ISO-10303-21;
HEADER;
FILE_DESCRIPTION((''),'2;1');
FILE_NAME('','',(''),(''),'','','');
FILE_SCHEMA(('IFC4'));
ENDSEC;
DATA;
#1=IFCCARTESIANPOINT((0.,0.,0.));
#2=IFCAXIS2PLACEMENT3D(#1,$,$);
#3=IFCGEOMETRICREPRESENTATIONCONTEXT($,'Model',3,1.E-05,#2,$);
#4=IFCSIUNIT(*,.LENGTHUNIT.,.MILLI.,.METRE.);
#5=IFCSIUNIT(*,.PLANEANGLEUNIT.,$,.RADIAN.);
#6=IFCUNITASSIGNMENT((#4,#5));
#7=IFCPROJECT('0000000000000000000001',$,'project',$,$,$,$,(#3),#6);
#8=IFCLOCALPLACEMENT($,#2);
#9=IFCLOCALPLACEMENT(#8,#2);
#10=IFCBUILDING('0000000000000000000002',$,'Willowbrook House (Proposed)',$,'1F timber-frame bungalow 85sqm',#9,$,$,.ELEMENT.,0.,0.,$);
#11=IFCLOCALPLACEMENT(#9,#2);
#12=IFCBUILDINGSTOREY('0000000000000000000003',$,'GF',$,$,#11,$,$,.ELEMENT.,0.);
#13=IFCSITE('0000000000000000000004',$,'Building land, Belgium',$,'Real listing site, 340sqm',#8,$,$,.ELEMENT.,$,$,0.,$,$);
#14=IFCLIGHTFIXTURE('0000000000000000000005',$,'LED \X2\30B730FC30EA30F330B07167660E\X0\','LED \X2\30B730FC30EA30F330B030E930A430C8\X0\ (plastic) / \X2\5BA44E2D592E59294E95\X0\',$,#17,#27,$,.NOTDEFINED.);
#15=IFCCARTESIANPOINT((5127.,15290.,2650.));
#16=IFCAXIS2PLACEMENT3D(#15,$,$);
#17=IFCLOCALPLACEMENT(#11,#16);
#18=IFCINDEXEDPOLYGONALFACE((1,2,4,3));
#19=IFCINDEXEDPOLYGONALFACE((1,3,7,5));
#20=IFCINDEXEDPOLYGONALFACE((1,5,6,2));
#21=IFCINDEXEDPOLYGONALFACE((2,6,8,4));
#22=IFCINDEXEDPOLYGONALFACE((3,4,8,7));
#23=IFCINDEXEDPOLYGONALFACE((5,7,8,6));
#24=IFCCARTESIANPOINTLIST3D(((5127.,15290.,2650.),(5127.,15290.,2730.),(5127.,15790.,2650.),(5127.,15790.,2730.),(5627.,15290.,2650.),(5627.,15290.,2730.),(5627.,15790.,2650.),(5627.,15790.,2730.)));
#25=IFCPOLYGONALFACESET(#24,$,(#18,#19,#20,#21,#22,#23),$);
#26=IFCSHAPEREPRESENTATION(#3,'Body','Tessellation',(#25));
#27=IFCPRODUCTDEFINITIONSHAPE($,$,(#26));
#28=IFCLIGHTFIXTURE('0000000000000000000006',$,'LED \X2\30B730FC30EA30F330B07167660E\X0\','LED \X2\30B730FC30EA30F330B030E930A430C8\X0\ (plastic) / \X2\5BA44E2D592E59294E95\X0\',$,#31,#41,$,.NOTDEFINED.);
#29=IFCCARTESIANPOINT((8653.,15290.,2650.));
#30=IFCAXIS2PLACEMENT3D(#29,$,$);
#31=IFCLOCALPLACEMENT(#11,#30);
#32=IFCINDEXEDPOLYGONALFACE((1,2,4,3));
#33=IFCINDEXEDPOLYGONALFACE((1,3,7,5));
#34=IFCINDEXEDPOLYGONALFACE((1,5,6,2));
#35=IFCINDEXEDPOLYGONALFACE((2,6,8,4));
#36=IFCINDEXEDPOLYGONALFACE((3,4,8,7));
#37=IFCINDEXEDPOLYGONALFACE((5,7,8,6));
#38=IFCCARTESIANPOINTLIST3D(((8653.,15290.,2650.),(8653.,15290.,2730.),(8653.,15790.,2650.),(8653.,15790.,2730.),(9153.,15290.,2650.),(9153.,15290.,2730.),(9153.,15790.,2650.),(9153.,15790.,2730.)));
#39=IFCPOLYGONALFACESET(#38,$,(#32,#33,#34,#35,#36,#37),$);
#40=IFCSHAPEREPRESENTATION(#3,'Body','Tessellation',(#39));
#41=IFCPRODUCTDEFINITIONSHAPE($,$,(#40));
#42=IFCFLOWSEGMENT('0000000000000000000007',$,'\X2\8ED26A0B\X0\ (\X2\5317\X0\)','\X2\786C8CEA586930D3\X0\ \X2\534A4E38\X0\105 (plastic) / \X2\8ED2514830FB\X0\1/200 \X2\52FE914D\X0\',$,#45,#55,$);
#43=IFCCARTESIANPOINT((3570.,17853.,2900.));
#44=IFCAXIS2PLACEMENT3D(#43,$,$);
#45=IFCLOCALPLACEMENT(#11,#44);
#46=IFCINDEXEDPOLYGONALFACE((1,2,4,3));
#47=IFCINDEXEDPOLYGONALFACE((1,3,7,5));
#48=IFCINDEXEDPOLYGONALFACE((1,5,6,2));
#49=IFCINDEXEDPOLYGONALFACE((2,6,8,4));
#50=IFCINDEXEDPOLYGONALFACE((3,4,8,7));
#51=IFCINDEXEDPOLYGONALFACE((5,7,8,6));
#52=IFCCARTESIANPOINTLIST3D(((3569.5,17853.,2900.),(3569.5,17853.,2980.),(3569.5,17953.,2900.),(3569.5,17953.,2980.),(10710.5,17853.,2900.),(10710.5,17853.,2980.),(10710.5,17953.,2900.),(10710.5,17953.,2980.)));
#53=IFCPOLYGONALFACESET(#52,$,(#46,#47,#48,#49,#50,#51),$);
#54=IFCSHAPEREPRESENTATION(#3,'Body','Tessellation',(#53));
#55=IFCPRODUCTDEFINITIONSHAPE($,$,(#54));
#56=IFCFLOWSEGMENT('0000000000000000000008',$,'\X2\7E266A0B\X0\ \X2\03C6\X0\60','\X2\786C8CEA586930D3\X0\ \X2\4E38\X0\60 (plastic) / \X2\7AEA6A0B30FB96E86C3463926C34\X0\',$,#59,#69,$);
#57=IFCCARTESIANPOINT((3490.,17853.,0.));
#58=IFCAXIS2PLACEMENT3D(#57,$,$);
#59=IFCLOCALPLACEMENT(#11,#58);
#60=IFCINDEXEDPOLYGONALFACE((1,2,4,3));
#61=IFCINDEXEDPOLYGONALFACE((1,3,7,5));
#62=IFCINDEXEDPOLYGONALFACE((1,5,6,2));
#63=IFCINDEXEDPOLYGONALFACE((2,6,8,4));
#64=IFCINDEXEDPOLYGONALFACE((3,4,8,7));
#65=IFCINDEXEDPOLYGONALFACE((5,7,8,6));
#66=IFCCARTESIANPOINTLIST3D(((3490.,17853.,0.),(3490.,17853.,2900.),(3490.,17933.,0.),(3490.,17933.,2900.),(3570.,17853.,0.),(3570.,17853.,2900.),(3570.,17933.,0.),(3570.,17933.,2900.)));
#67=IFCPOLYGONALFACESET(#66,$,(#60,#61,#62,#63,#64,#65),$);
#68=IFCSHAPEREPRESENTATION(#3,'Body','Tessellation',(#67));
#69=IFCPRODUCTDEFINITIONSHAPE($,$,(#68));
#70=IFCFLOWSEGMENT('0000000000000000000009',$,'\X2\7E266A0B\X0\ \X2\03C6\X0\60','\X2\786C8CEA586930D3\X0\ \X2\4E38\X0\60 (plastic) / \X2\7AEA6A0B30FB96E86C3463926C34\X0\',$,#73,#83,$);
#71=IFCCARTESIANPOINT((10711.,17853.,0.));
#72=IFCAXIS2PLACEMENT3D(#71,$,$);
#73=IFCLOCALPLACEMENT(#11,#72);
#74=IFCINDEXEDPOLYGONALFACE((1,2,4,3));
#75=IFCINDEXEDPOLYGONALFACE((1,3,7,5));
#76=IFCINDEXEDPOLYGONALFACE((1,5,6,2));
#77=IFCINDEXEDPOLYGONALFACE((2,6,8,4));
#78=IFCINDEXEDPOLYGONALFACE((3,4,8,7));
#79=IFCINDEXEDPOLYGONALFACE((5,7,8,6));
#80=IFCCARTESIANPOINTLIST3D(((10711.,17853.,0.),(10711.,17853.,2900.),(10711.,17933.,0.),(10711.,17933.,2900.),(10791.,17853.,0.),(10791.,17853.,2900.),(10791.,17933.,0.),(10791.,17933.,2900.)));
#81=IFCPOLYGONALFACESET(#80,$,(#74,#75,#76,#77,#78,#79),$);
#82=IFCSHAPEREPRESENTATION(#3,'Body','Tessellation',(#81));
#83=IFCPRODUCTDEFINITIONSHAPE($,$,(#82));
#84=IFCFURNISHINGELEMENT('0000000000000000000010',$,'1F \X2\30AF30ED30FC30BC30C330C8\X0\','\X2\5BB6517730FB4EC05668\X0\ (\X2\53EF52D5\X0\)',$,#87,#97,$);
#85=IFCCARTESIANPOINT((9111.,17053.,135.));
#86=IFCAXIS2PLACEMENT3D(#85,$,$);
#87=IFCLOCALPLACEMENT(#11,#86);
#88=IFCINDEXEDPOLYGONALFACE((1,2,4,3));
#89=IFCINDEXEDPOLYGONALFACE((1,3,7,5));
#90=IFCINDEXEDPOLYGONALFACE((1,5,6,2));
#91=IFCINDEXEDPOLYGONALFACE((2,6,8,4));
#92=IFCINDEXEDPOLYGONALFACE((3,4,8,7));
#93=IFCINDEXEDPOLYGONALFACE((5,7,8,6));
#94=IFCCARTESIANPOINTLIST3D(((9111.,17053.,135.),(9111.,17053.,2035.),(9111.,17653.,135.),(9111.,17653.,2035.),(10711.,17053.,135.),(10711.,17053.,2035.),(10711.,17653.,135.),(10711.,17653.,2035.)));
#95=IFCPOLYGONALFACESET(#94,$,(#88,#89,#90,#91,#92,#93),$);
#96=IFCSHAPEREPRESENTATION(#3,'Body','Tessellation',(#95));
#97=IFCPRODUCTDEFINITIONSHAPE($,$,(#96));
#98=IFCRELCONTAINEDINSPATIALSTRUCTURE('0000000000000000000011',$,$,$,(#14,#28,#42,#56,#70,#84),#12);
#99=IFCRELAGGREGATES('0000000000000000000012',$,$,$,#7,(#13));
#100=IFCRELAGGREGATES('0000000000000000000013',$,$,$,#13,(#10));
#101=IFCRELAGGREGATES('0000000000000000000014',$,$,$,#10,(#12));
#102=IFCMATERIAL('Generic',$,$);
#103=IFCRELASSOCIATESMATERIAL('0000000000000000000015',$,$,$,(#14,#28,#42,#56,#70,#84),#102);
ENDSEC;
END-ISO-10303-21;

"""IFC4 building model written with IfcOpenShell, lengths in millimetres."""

from ifc_helpers import new_model, si_unit, frame, frame_2d, origin, place, context, project, spatial, rectangle, extrude, material, element, save


model = new_model("IFC4")

# Units and contexts
model_context = context("Model", 3, precision=1e-05, world=origin())
ifc_project = project(units=[si_unit("LENGTHUNIT", "METRE", prefix="MILLI"), si_unit("PLANEANGLEUNIT", "RADIAN")], contexts=[model_context])

# Site, building, storey
site_placement = place(None, origin())
site = spatial("IfcSite", under=ifc_project, at=site_placement, Name="Building land, Belgium", ObjectType="Real listing site, 340sqm", CompositionType="ELEMENT", RefElevation=0.0)
building_placement = place(site_placement, origin())
building = spatial("IfcBuilding", under=site, at=building_placement, Name="Willowbrook House (Proposed)", ObjectType="1F timber-frame bungalow 85sqm", CompositionType="ELEMENT", ElevationOfRefHeight=0.0, ElevationOfTerrain=0.0)
storey_placement = place(building_placement, origin())
storey = spatial("IfcBuildingStorey", under=building, at=storey_placement, Name="GF", CompositionType="ELEMENT", Elevation=0.0)

# Shared definitions
ifc_material_1 = material(Name="Generic")

# Light fixtures
light_fixture_1_placement = place(storey_placement, frame((5127.0, 15290.0, 2650.0)))
element("IfcLightFixture", 1, at=light_fixture_1_placement, inside=storey, material=ifc_material_1, Name="LED シーリング照明", Description="LED シーリングライト (plastic) / 室中央天井", PredefinedType="NOTDEFINED", context=model_context, shape_type="SweptSolid", body=[
    extrude(rectangle(XDim=500.0, YDim=500.0, at=frame_2d((250.0, 250.0))), frame((5127.0, 15290.0, 2650.0)), (0.0, 0.0, 1.0), 80.0),
])
light_fixture_2_placement = place(storey_placement, frame((8653.0, 15290.0, 2650.0)))
element("IfcLightFixture", 2, at=light_fixture_2_placement, inside=storey, material=ifc_material_1, Name="LED シーリング照明", Description="LED シーリングライト (plastic) / 室中央天井", PredefinedType="NOTDEFINED", context=model_context, shape_type="SweptSolid", body=[
    extrude(rectangle(XDim=500.0, YDim=500.0, at=frame_2d((250.0, 250.0))), frame((8653.0, 15290.0, 2650.0)), (0.0, 0.0, 1.0), 80.0),
])

# Flow segments
flow_segment_1_placement = place(storey_placement, frame((3570.0, 17853.0, 2900.0)))
element("IfcFlowSegment", 3, at=flow_segment_1_placement, inside=storey, material=ifc_material_1, Name="軒樋 (北)", Description="硬質塩ビ 半丸105 (plastic) / 軒先・1/200 勾配", context=model_context, shape_type="SweptSolid", body=[
    extrude(rectangle(XDim=7141.0, YDim=100.0, at=frame_2d((3570.0, 50.0))), frame((3570.0, 17853.0, 2900.0)), (0.0, 0.0, 1.0), 80.0),
])
flow_segment_2_placement = place(storey_placement, frame((3490.0, 17853.0, 0.0)))
element("IfcFlowSegment", 4, at=flow_segment_2_placement, inside=storey, material=ifc_material_1, Name="縦樋 φ60", Description="硬質塩ビ 丸60 (plastic) / 竪樋・雨水排水", context=model_context, shape_type="SweptSolid", body=[
    extrude(rectangle(XDim=80.0, YDim=80.0, at=frame_2d((40.0, 40.0))), frame((3490.0, 17853.0, 0.0)), (0.0, 0.0, 1.0), 2900.0),
])
flow_segment_3_placement = place(storey_placement, frame((10711.0, 17853.0, 0.0)))
element("IfcFlowSegment", 5, at=flow_segment_3_placement, inside=storey, material=ifc_material_1, Name="縦樋 φ60", Description="硬質塩ビ 丸60 (plastic) / 竪樋・雨水排水", context=model_context, shape_type="SweptSolid", body=[
    extrude(rectangle(XDim=80.0, YDim=80.0, at=frame_2d((40.0, 40.0))), frame((10711.0, 17853.0, 0.0)), (0.0, 0.0, 1.0), 2900.0),
])

# Furnishing element
furnishing_placement = place(storey_placement, frame((9111.0, 17053.0, 135.0)))
element("IfcFurnishingElement", 6, at=furnishing_placement, inside=storey, material=ifc_material_1, Name="1F クローゼット", Description="家具・什器 (可動)", context=model_context, shape_type="SweptSolid", body=[
    extrude(rectangle(XDim=1600.0, YDim=600.0, at=frame_2d((800.0, 300.0))), frame((9111.0, 17053.0, 135.0)), (0.0, 0.0, 1.0), 1900.0),
])

save(model, "model.ifc")
